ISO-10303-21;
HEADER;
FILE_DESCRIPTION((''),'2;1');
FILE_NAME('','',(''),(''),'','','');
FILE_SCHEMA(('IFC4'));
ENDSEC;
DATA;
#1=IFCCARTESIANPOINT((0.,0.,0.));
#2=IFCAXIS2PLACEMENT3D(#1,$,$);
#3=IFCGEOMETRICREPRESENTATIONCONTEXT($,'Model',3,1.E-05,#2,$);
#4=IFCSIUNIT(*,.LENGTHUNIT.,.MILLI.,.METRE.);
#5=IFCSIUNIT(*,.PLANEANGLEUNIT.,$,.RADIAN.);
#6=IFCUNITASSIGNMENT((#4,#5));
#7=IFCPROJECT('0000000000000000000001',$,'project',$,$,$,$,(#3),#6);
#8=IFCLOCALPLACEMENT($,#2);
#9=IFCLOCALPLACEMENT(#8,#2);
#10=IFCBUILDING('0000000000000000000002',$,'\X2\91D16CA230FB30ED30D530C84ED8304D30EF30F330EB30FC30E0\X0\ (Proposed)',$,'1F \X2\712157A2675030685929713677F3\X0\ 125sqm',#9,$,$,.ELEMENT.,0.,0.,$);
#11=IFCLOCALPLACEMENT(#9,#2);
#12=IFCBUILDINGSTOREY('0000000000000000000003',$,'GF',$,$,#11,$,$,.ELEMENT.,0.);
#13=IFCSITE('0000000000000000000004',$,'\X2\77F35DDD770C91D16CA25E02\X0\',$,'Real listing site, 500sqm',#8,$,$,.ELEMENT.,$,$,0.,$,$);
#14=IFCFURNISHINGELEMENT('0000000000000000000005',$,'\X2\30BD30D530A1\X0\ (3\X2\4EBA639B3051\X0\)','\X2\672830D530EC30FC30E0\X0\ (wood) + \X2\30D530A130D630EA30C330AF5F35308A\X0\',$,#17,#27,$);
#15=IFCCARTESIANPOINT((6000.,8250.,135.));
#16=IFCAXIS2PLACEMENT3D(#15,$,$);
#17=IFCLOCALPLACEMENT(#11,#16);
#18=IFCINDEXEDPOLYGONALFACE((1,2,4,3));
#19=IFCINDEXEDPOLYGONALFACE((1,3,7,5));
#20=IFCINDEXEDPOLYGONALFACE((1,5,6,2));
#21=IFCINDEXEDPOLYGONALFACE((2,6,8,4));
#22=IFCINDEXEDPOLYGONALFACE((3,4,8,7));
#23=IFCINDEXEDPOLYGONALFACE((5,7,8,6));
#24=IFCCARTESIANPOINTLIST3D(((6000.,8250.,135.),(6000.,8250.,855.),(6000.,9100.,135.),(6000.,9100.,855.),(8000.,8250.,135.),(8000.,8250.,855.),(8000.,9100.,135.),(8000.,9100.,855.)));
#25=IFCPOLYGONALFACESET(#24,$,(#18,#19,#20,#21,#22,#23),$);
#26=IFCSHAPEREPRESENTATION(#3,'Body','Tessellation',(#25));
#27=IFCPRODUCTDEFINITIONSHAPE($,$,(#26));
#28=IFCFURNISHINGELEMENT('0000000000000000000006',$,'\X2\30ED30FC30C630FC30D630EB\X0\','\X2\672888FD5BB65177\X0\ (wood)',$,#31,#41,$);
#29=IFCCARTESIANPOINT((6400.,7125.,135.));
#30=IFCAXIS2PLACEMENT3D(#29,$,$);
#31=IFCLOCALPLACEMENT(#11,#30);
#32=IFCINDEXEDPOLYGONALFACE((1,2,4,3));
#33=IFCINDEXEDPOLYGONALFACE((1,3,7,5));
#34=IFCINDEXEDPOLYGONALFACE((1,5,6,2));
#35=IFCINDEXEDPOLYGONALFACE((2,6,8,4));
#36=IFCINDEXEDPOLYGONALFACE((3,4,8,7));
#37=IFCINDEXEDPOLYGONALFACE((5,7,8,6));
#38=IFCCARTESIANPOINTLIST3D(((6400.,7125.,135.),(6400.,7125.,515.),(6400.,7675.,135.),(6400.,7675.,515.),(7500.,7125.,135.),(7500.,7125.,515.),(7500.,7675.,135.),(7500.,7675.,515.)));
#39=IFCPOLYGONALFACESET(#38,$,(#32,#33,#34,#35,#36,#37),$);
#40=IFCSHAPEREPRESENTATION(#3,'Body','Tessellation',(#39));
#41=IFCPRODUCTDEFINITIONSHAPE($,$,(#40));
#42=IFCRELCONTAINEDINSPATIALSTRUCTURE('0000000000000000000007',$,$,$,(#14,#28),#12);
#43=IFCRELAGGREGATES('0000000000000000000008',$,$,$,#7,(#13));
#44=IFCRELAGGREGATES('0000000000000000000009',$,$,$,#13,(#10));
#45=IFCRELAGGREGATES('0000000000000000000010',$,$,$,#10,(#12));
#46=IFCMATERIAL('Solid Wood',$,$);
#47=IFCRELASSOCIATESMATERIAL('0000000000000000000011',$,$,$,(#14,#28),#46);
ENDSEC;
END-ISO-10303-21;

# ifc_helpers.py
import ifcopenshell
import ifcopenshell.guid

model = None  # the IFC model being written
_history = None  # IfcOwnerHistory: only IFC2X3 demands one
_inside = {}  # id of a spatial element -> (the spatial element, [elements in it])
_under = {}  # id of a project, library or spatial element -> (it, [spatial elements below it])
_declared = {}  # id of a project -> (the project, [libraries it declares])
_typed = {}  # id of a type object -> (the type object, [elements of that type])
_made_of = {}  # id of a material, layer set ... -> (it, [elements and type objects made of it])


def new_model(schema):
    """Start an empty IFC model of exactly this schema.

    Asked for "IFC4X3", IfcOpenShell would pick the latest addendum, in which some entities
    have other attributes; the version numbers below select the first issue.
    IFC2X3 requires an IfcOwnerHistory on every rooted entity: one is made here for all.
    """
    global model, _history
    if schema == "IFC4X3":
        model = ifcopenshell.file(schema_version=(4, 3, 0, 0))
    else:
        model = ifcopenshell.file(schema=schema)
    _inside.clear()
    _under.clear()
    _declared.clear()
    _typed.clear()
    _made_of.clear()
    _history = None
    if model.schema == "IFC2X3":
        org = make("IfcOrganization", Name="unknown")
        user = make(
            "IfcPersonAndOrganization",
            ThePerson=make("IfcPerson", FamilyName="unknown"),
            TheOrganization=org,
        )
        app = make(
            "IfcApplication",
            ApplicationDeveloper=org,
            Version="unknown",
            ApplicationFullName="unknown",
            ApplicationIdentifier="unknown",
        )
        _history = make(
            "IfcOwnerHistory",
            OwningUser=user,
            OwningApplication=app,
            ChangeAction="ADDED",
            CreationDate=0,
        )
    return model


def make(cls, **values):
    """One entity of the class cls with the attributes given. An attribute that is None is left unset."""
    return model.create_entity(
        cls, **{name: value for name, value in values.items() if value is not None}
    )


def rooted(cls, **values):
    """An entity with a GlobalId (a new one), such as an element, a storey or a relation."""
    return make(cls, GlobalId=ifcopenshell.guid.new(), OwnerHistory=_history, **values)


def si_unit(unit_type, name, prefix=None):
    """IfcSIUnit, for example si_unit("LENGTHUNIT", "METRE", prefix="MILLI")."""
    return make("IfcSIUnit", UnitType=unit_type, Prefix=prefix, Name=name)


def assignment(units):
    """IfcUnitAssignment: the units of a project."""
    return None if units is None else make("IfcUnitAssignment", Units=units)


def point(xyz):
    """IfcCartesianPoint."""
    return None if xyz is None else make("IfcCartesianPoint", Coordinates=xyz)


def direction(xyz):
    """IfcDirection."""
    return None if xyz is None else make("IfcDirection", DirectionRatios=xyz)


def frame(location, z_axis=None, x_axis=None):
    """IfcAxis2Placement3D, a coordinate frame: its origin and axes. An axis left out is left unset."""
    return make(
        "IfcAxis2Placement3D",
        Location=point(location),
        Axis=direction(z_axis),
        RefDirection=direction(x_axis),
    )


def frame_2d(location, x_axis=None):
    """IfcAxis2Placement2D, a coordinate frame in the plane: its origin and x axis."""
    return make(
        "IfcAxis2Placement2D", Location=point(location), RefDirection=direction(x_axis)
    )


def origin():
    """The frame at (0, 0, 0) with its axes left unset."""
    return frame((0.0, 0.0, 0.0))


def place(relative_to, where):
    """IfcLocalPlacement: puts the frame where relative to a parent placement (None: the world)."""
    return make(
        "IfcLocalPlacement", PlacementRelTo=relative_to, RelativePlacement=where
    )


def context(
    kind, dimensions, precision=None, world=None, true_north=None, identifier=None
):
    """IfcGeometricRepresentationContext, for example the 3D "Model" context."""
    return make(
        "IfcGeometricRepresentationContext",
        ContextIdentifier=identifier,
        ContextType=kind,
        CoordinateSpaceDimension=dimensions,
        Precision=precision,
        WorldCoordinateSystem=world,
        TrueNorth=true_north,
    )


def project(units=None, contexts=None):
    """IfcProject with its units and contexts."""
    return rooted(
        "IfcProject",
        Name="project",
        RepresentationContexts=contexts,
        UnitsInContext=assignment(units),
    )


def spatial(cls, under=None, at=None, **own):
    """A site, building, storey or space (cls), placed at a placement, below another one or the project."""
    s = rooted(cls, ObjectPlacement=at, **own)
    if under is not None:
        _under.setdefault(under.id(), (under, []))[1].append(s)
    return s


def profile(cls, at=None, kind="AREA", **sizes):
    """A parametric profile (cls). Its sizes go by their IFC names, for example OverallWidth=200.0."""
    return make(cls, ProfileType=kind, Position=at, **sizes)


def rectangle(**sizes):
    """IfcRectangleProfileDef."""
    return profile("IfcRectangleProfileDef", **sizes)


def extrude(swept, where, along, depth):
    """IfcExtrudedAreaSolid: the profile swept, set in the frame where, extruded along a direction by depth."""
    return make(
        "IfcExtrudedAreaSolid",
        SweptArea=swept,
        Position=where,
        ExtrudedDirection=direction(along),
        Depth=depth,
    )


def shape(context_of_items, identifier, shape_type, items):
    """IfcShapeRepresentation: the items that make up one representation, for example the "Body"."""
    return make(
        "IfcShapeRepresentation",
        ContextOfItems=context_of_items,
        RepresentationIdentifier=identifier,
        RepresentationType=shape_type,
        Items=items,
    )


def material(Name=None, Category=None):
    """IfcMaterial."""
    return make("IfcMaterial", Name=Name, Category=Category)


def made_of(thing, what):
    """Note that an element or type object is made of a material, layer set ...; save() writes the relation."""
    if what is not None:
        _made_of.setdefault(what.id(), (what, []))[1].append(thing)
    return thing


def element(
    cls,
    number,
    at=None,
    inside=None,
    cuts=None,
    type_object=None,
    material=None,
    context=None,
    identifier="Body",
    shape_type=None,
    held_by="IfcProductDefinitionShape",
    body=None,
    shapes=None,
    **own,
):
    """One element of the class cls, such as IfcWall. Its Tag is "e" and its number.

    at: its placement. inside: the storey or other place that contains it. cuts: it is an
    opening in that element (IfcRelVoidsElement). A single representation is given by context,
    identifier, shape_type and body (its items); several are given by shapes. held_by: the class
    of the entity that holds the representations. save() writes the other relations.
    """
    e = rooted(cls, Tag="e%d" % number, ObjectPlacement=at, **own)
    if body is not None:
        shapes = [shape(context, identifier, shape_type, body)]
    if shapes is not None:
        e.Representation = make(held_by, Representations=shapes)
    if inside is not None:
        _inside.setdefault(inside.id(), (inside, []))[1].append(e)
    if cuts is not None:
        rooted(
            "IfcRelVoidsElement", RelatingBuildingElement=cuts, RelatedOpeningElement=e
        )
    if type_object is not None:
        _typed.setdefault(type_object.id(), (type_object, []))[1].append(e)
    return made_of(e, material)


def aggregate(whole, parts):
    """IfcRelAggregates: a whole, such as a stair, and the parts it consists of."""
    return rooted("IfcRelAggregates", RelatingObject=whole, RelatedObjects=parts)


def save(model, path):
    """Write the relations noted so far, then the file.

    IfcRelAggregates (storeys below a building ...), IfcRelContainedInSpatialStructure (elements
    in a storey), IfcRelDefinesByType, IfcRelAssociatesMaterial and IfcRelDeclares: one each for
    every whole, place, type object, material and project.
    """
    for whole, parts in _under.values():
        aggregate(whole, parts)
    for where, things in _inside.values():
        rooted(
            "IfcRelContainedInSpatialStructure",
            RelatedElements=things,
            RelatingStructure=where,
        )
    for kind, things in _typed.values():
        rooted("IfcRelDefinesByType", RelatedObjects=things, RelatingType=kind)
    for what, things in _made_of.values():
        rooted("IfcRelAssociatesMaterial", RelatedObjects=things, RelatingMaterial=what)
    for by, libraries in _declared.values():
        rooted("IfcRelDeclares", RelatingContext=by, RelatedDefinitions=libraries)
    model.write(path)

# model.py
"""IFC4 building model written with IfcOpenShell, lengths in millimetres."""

from ifc_helpers import new_model, si_unit, frame, frame_2d, origin, place, context, project, spatial, rectangle, extrude, material, element, save


model = new_model("IFC4")

# Units and contexts
model_context = context("Model", 3, precision=1e-05, world=origin())
ifc_project = project(units=[si_unit("LENGTHUNIT", "METRE", prefix="MILLI"), si_unit("PLANEANGLEUNIT", "RADIAN")], contexts=[model_context])

# Site, building, storey
site_placement = place(None, origin())
site = spatial("IfcSite", under=ifc_project, at=site_placement, Name="石川県金沢市", ObjectType="Real listing site, 500sqm", CompositionType="ELEMENT", RefElevation=0.0)
building_placement = place(site_placement, origin())
building = spatial("IfcBuilding", under=site, at=building_placement, Name="金沢・ロフト付きワンルーム (Proposed)", ObjectType="1F 無垢材と天然石 125sqm", CompositionType="ELEMENT", ElevationOfRefHeight=0.0, ElevationOfTerrain=0.0)
storey_placement = place(building_placement, origin())
storey = spatial("IfcBuildingStorey", under=building, at=storey_placement, Name="GF", CompositionType="ELEMENT", Elevation=0.0)

# Shared definitions
ifc_material_1 = material(Name="Solid Wood")

# Furnishing elements
furnishing_1_placement = place(storey_placement, frame((6000.0, 8250.0, 135.0)))
element("IfcFurnishingElement", 1, at=furnishing_1_placement, inside=storey, material=ifc_material_1, Name="ソファ (3人掛け)", Description="木フレーム (wood) + ファブリック張り", context=model_context, shape_type="SweptSolid", body=[
    extrude(rectangle(XDim=2000.0, YDim=850.0, at=frame_2d((1000.0, 425.0))), frame((6000.0, 8250.0, 135.0)), (0.0, 0.0, 1.0), 720.0),
])
furnishing_2_placement = place(storey_placement, frame((6400.0, 7125.0, 135.0)))
element("IfcFurnishingElement", 2, at=furnishing_2_placement, inside=storey, material=ifc_material_1, Name="ローテーブル", Description="木製家具 (wood)", context=model_context, shape_type="SweptSolid", body=[
    extrude(rectangle(XDim=1100.0, YDim=550.0, at=frame_2d((550.0, 275.0))), frame((6400.0, 7125.0, 135.0)), (0.0, 0.0, 1.0), 380.0),
])

save(model, "model.ifc")
